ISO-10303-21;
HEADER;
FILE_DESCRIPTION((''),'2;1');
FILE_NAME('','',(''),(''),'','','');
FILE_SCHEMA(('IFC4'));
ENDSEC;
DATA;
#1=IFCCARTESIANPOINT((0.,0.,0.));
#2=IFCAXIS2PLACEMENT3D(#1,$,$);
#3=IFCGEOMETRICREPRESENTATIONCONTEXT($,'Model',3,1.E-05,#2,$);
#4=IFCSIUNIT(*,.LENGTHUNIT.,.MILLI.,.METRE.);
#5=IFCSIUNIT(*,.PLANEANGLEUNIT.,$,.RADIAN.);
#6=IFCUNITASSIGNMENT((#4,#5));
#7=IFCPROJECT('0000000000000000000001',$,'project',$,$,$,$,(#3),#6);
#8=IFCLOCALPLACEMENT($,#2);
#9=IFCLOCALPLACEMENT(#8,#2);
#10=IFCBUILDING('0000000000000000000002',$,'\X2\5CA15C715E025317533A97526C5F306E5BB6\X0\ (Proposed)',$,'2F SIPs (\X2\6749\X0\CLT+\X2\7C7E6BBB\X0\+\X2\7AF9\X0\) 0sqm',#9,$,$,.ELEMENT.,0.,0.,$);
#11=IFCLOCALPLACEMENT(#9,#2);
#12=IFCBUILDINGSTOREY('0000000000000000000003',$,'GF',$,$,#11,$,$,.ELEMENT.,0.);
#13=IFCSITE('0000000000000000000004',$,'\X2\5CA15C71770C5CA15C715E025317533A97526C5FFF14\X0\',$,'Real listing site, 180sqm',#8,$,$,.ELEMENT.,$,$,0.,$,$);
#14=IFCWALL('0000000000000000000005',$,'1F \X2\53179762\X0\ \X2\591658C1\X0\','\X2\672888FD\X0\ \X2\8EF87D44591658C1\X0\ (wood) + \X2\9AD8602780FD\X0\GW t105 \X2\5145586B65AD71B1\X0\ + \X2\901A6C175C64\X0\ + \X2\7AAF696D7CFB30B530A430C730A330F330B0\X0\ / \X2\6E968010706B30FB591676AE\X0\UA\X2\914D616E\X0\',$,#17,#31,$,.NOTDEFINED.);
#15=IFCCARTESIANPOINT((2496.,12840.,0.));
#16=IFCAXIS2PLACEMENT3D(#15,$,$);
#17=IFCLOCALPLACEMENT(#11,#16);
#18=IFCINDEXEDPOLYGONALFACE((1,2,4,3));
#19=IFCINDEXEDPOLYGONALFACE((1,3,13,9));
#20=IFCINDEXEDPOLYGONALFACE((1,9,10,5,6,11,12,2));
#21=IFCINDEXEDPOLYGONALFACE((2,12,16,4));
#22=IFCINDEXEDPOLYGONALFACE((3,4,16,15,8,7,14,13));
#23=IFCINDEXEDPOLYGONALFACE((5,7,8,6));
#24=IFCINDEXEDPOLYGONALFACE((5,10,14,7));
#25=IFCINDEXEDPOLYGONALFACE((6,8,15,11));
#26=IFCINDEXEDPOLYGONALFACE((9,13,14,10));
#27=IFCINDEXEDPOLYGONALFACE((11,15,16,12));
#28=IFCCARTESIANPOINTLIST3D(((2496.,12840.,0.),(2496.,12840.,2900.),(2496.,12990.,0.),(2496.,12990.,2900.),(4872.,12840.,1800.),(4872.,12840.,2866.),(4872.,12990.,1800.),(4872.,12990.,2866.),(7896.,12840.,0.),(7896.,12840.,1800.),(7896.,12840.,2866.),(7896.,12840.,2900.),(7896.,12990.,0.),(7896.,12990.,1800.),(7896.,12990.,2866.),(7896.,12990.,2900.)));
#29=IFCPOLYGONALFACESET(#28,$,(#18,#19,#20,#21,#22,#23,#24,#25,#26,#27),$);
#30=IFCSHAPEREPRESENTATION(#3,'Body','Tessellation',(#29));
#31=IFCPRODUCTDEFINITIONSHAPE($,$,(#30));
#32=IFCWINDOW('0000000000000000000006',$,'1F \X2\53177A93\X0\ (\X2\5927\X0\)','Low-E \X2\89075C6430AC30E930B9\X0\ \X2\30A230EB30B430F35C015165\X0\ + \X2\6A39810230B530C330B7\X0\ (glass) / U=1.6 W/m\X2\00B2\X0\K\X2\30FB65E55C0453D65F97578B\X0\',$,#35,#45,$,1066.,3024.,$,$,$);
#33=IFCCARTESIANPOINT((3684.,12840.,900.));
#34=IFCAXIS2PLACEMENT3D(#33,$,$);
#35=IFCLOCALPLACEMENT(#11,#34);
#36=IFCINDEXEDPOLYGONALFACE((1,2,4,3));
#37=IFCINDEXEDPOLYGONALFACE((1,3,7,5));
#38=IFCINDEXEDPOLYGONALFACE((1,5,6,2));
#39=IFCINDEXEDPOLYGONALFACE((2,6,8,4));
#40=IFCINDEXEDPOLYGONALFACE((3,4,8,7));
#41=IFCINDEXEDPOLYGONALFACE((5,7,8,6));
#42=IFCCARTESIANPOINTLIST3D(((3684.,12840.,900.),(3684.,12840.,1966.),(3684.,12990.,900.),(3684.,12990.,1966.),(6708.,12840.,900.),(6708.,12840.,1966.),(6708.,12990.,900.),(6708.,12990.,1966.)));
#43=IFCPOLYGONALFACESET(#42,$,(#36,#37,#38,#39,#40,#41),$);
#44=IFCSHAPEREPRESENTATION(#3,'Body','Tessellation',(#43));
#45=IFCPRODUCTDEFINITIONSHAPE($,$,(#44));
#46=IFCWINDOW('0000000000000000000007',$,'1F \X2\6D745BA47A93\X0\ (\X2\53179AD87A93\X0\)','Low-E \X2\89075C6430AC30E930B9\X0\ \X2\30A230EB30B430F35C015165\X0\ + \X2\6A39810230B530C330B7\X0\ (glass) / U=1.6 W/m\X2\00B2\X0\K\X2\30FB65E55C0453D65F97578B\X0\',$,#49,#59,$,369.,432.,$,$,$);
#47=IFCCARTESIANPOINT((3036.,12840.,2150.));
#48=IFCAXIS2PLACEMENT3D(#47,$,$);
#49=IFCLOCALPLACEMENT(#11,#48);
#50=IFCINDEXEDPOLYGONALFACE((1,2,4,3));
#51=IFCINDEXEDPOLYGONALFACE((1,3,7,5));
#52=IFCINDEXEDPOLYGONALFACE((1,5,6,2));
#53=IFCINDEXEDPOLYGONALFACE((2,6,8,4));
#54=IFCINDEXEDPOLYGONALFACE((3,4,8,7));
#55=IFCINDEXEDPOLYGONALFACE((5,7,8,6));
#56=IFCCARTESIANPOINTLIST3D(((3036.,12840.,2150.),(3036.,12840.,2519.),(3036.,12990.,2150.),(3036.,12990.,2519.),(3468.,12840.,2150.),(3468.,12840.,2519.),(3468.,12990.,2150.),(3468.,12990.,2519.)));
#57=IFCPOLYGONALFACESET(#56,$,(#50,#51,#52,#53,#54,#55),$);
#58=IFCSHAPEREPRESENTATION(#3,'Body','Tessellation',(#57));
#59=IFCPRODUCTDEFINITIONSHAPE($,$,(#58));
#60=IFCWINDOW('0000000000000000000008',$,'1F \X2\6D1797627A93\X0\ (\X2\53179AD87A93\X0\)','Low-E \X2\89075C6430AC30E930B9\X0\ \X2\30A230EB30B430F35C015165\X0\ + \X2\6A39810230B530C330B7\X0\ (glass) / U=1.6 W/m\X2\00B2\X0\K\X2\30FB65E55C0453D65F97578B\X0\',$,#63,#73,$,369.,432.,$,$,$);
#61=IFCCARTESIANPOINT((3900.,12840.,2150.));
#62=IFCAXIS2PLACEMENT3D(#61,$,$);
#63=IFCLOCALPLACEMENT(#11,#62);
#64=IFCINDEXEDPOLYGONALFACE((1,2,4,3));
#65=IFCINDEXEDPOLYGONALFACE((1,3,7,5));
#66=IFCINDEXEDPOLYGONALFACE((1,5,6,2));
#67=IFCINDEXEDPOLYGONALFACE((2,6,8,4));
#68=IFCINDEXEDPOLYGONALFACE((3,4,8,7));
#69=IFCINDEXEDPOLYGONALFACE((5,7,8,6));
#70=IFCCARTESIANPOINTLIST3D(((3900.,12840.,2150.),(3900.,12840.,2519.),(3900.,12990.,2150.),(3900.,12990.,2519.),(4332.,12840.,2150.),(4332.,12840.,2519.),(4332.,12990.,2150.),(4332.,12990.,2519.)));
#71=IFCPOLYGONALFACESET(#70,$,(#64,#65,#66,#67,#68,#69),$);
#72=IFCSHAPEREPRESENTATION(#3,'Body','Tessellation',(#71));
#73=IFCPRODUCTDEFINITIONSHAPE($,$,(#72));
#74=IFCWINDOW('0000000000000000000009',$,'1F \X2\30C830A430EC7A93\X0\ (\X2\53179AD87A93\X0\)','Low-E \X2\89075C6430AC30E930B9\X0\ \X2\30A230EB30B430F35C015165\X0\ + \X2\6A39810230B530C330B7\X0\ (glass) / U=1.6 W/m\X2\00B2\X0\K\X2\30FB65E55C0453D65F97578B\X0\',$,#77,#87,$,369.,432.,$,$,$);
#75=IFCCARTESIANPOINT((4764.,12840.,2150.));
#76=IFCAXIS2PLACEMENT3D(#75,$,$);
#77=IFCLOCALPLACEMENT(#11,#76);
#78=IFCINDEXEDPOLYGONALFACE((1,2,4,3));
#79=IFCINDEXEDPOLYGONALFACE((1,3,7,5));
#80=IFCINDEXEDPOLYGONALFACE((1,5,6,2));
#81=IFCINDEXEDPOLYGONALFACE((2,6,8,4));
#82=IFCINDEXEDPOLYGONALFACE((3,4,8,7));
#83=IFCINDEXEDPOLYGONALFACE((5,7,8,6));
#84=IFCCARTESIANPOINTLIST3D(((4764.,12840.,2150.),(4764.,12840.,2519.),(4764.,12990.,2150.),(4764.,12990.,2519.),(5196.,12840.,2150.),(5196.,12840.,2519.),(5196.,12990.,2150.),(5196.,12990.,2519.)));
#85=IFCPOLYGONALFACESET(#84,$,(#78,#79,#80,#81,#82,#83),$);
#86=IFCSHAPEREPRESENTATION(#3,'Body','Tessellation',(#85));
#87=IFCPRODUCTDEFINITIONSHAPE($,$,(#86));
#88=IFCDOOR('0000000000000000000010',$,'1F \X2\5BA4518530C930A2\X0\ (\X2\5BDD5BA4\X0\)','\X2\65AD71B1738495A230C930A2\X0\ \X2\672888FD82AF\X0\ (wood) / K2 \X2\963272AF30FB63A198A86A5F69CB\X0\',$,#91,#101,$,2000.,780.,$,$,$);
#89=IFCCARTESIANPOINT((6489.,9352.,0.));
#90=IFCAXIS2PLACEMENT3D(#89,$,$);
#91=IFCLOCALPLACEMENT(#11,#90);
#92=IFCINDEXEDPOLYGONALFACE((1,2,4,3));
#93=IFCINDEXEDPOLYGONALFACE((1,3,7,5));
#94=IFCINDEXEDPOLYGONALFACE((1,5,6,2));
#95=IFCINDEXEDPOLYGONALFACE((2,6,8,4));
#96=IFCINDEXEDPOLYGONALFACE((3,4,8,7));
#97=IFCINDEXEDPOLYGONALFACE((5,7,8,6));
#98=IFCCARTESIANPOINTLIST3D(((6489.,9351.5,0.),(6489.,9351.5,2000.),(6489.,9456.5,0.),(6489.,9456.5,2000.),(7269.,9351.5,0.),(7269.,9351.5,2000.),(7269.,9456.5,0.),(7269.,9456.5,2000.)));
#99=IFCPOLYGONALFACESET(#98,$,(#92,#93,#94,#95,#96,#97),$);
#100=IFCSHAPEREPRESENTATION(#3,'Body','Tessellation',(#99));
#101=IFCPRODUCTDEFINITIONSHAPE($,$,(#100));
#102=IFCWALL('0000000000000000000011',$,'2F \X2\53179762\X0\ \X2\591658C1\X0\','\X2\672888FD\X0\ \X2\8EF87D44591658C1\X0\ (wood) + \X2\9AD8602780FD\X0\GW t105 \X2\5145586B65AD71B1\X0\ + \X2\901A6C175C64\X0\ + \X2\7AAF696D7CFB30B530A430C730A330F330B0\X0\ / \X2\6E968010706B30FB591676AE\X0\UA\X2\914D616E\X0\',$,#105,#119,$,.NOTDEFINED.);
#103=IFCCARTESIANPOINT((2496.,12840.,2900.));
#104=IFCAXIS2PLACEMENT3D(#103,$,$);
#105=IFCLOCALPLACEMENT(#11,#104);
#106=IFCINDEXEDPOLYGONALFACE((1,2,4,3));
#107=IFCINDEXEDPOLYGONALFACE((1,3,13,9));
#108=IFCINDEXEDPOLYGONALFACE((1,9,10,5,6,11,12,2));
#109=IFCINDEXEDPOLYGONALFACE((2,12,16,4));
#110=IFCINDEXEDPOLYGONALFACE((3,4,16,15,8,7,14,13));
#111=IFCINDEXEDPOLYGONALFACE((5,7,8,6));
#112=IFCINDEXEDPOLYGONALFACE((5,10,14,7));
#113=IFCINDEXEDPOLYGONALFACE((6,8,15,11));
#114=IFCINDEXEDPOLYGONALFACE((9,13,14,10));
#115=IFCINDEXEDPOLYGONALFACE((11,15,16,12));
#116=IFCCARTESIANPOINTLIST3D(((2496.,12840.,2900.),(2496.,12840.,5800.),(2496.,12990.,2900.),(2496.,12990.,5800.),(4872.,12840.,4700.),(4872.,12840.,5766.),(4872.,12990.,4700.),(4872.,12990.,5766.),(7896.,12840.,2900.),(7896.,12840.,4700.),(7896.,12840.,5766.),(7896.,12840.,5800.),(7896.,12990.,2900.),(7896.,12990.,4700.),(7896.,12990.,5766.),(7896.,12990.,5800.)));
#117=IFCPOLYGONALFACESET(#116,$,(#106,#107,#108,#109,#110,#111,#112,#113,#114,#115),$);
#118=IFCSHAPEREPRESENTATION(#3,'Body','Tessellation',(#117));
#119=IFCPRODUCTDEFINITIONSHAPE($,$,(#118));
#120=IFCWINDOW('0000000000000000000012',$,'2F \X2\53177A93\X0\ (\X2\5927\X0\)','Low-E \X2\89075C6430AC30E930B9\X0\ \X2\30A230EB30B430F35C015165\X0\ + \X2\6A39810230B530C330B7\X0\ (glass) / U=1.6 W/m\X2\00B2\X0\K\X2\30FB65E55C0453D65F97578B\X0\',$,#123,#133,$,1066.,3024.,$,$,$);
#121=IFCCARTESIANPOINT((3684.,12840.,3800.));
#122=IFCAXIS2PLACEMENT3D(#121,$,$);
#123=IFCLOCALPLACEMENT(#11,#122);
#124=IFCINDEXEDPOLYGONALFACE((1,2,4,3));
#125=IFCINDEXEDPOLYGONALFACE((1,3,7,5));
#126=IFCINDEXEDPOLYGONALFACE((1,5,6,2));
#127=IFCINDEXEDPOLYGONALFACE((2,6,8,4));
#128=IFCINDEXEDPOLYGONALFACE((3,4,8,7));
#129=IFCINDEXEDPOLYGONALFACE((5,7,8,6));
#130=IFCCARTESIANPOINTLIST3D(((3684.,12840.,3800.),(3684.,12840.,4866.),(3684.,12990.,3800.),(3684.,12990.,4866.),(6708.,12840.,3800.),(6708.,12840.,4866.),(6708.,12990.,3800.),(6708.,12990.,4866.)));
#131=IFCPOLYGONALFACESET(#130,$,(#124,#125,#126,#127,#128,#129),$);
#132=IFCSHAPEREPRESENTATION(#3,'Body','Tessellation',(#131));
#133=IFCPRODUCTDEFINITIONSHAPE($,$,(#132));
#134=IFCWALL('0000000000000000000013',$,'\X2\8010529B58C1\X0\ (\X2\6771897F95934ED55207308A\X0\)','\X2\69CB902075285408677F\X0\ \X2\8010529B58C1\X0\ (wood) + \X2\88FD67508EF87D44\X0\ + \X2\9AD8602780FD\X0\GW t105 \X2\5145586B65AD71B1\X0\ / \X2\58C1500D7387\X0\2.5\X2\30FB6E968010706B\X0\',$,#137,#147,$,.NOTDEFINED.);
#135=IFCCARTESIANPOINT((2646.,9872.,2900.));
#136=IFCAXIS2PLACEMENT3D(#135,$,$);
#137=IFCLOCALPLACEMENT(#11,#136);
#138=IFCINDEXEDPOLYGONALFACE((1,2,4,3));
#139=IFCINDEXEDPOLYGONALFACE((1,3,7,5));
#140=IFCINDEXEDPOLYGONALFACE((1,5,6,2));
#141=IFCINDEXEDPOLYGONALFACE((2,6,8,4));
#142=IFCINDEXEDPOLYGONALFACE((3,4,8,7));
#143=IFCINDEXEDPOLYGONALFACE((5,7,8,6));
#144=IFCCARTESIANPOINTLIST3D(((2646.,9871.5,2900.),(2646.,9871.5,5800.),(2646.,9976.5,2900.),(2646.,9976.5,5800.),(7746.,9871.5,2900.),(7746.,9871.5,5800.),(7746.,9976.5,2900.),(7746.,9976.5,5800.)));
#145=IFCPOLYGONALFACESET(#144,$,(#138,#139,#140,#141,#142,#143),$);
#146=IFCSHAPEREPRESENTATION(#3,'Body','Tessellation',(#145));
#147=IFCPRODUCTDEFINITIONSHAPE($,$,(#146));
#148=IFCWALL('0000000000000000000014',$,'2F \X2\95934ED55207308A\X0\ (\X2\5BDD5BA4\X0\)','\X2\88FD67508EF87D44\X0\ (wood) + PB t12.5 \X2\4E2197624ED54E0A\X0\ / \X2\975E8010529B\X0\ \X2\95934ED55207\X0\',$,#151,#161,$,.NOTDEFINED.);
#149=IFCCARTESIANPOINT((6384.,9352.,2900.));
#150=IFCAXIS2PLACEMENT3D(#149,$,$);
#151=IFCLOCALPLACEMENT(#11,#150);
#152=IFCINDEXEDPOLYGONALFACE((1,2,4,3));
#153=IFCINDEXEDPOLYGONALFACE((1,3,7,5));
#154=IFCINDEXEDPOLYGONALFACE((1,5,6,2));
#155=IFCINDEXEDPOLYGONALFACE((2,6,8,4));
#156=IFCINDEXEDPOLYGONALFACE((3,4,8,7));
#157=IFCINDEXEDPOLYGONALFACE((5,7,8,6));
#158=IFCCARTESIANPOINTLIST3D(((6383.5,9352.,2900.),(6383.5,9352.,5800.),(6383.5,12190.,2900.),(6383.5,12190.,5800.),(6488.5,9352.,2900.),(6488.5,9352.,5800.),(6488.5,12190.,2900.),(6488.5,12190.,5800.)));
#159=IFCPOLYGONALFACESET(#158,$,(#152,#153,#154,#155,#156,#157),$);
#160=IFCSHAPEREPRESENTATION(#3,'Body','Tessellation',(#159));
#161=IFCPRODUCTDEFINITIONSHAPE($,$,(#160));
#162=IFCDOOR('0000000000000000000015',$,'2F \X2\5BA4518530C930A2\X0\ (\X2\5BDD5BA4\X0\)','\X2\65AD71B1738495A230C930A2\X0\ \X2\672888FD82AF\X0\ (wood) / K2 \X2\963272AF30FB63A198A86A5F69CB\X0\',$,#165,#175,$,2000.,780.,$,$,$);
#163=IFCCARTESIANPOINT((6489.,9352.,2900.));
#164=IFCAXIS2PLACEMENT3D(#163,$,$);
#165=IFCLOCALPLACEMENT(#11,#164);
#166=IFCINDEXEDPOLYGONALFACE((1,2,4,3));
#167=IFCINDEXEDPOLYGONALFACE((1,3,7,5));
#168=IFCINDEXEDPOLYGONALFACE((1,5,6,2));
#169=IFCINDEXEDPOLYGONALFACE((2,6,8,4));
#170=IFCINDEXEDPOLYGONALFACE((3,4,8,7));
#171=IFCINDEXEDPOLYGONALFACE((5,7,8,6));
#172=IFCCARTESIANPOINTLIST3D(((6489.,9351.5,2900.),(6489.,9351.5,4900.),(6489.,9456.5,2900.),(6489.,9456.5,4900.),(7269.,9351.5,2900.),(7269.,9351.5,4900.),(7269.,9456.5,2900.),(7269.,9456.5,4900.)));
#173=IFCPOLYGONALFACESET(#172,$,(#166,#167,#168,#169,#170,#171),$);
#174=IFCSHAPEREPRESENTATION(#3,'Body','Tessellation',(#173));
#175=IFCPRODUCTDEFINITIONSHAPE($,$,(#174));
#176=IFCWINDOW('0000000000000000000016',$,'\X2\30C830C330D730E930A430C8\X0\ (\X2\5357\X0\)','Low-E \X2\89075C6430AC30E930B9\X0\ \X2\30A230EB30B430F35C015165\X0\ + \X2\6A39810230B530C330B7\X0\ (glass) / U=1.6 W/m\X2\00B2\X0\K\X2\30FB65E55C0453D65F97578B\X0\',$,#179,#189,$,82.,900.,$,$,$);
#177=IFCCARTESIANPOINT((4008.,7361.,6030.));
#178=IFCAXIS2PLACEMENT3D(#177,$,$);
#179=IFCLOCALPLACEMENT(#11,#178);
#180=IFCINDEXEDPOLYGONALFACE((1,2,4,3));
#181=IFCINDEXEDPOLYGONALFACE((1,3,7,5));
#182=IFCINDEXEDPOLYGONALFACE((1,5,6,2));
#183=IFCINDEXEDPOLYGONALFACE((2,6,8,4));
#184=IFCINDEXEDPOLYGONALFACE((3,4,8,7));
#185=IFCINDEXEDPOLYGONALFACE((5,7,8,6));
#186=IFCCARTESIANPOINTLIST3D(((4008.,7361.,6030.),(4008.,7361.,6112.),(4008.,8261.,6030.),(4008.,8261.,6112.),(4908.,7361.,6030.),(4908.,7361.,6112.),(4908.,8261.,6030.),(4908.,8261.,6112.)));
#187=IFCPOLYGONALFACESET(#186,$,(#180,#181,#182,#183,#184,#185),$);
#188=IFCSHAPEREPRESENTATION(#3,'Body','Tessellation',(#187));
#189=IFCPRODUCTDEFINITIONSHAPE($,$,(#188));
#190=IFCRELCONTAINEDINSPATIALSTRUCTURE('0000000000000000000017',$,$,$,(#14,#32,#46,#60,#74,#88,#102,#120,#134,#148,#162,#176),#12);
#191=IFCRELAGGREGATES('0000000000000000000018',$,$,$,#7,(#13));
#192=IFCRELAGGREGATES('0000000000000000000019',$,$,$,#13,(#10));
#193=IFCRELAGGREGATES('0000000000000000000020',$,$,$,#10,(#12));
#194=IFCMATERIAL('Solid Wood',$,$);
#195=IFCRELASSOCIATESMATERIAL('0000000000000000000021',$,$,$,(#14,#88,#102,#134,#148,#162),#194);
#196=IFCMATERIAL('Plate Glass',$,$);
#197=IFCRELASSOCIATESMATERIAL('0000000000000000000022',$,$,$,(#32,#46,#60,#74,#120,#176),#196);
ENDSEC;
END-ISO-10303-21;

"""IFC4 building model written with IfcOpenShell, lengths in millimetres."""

from ifc_helpers import new_model, si_unit, frame, frame_2d, origin, place, context, project, spatial, rectangle, extrude, material, element, fill, save


model = new_model("IFC4")

# Units and contexts
model_context = context("Model", 3, precision=1e-05, world=origin())
ifc_project = project(units=[si_unit("LENGTHUNIT", "METRE", prefix="MILLI"), si_unit("PLANEANGLEUNIT", "RADIAN")], contexts=[model_context])

# Site, building, storey
site_placement = place(None, origin())
site = spatial("IfcSite", under=ifc_project, at=site_placement, Name="岡山県岡山市北区青江４", ObjectType="Real listing site, 180sqm", CompositionType="ELEMENT", RefElevation=0.0)
building_placement = place(site_placement, origin())
building = spatial("IfcBuilding", under=site, at=building_placement, Name="岡山市北区青江の家 (Proposed)", ObjectType="2F SIPs (杉CLT+籾殻+竹) 0sqm", CompositionType="ELEMENT", ElevationOfRefHeight=0.0, ElevationOfTerrain=0.0)
storey_placement = place(building_placement, origin())
storey = spatial("IfcBuildingStorey", under=building, at=storey_placement, Name="GF", CompositionType="ELEMENT", Elevation=0.0)

# Wall, openings, windows
ifc_material_1 = material(Name="Solid Wood")
wall_1_placement = place(storey_placement, frame((2496.0, 12840.0, 0.0)))
wall_1 = element("IfcWall", 1, at=wall_1_placement, inside=storey, material=ifc_material_1, Name="1F 北面 外壁", Description="木製 軸組外壁 (wood) + 高性能GW t105 充填断熱 + 通気層 + 窯業系サイディング / 準耐火・外皮UA配慮", PredefinedType="NOTDEFINED", context=model_context, shape_type="SweptSolid", body=[
    extrude(rectangle(XDim=5400.0, YDim=150.0, at=frame_2d((2700.0, 75.0))), frame((2496.0, 12840.0, 0.0)), (0.0, 0.0, 1.0), 2900.0),
])
opening_1_placement = place(storey_placement, frame((3684.0, 12840.0, 900.0)))
opening_1 = element("IfcOpeningElement", 2, at=opening_1_placement, cuts=wall_1, PredefinedType="NOTDEFINED", context=model_context, shape_type="SweptSolid", body=[
    extrude(rectangle(XDim=3024.0, YDim=150.0, at=frame_2d((1512.0, 75.0))), frame((3684.0, 12840.0, 900.0)), (0.0, 0.0, 1.0), 1066.0),
])
opening_2_placement = place(storey_placement, frame((3036.0, 12840.0, 2150.0)))
opening_2 = element("IfcOpeningElement", 3, at=opening_2_placement, cuts=wall_1, PredefinedType="NOTDEFINED", context=model_context, shape_type="SweptSolid", body=[
    extrude(rectangle(XDim=432.0, YDim=150.0, at=frame_2d((216.0, 75.0))), frame((3036.0, 12840.0, 2150.0)), (0.0, 0.0, 1.0), 369.0),
])
opening_3_placement = place(storey_placement, frame((3900.0, 12840.0, 2150.0)))
opening_3 = element("IfcOpeningElement", 4, at=opening_3_placement, cuts=wall_1, PredefinedType="NOTDEFINED", context=model_context, shape_type="SweptSolid", body=[
    extrude(rectangle(XDim=432.0, YDim=150.0, at=frame_2d((216.0, 75.0))), frame((3900.0, 12840.0, 2150.0)), (0.0, 0.0, 1.0), 369.0),
])
opening_4_placement = place(storey_placement, frame((4764.0, 12840.0, 2150.0)))
opening_4 = element("IfcOpeningElement", 5, at=opening_4_placement, cuts=wall_1, PredefinedType="NOTDEFINED", context=model_context, shape_type="SweptSolid", body=[
    extrude(rectangle(XDim=432.0, YDim=150.0, at=frame_2d((216.0, 75.0))), frame((4764.0, 12840.0, 2150.0)), (0.0, 0.0, 1.0), 369.0),
])
ifc_material_2 = material(Name="Plate Glass")
window_1_placement = place(storey_placement, frame((3684.0, 12840.0, 900.0)))
window_1 = element("IfcWindow", 6, at=window_1_placement, inside=storey, material=ifc_material_2, Name="1F 北窓 (大)", Description="Low-E 複層ガラス アルゴン封入 + 樹脂サッシ (glass) / U=1.6 W/m²K・日射取得型", OverallHeight=1066.0, OverallWidth=3024.0, context=model_context, shape_type="SweptSolid", body=[
    extrude(rectangle(XDim=3024.0, YDim=150.0, at=frame_2d((1512.0, 75.0))), frame((3684.0, 12840.0, 900.0)), (0.0, 0.0, 1.0), 1066.0),
])
fill(opening_1, window_1)
window_2_placement = place(storey_placement, frame((3036.0, 12840.0, 2150.0)))
window_2 = element("IfcWindow", 7, at=window_2_placement, inside=storey, material=ifc_material_2, Name="1F 浴室窓 (北高窓)", Description="Low-E 複層ガラス アルゴン封入 + 樹脂サッシ (glass) / U=1.6 W/m²K・日射取得型", OverallHeight=369.0, OverallWidth=432.0, context=model_context, shape_type="SweptSolid", body=[
    extrude(rectangle(XDim=432.0, YDim=150.0, at=frame_2d((216.0, 75.0))), frame((3036.0, 12840.0, 2150.0)), (0.0, 0.0, 1.0), 369.0),
])
fill(opening_2, window_2)
window_3_placement = place(storey_placement, frame((3900.0, 12840.0, 2150.0)))
window_3 = element("IfcWindow", 8, at=window_3_placement, inside=storey, material=ifc_material_2, Name="1F 洗面窓 (北高窓)", Description="Low-E 複層ガラス アルゴン封入 + 樹脂サッシ (glass) / U=1.6 W/m²K・日射取得型", OverallHeight=369.0, OverallWidth=432.0, context=model_context, shape_type="SweptSolid", body=[
    extrude(rectangle(XDim=432.0, YDim=150.0, at=frame_2d((216.0, 75.0))), frame((3900.0, 12840.0, 2150.0)), (0.0, 0.0, 1.0), 369.0),
])
fill(opening_3, window_3)
window_4_placement = place(storey_placement, frame((4764.0, 12840.0, 2150.0)))
window_4 = element("IfcWindow", 9, at=window_4_placement, inside=storey, material=ifc_material_2, Name="1F トイレ窓 (北高窓)", Description="Low-E 複層ガラス アルゴン封入 + 樹脂サッシ (glass) / U=1.6 W/m²K・日射取得型", OverallHeight=369.0, OverallWidth=432.0, context=model_context, shape_type="SweptSolid", body=[
    extrude(rectangle(XDim=432.0, YDim=150.0, at=frame_2d((216.0, 75.0))), frame((4764.0, 12840.0, 2150.0)), (0.0, 0.0, 1.0), 369.0),
])
fill(opening_4, window_4)

# Door
door_1_placement = place(storey_placement, frame((6489.0, 9352.0, 0.0)))
element("IfcDoor", 10, at=door_1_placement, inside=storey, material=ifc_material_1, Name="1F 室内ドア (寝室)", Description="断熱玄関ドア 木製芯 (wood) / K2 防犯・採風機構", OverallHeight=2000.0, OverallWidth=780.0, context=model_context, shape_type="SweptSolid", body=[
    extrude(rectangle(XDim=780.0, YDim=105.0, at=frame_2d((390.0, 52.0))), frame((6489.0, 9352.0, 0.0)), (0.0, 0.0, 1.0), 2000.0),
])

# Wall, opening, window
wall_2_placement = place(storey_placement, frame((2496.0, 12840.0, 2900.0)))
wall_2 = element("IfcWall", 11, at=wall_2_placement, inside=storey, material=ifc_material_1, Name="2F 北面 外壁", Description="木製 軸組外壁 (wood) + 高性能GW t105 充填断熱 + 通気層 + 窯業系サイディング / 準耐火・外皮UA配慮", PredefinedType="NOTDEFINED", context=model_context, shape_type="SweptSolid", body=[
    extrude(rectangle(XDim=5400.0, YDim=150.0, at=frame_2d((2700.0, 75.0))), frame((2496.0, 12840.0, 2900.0)), (0.0, 0.0, 1.0), 2900.0),
])
opening_5_placement = place(storey_placement, frame((3684.0, 12840.0, 3800.0)))
opening_5 = element("IfcOpeningElement", 12, at=opening_5_placement, cuts=wall_2, PredefinedType="NOTDEFINED", context=model_context, shape_type="SweptSolid", body=[
    extrude(rectangle(XDim=3024.0, YDim=150.0, at=frame_2d((1512.0, 75.0))), frame((3684.0, 12840.0, 3800.0)), (0.0, 0.0, 1.0), 1066.0),
])
window_5_placement = place(storey_placement, frame((3684.0, 12840.0, 3800.0)))
window_5 = element("IfcWindow", 13, at=window_5_placement, inside=storey, material=ifc_material_2, Name="2F 北窓 (大)", Description="Low-E 複層ガラス アルゴン封入 + 樹脂サッシ (glass) / U=1.6 W/m²K・日射取得型", OverallHeight=1066.0, OverallWidth=3024.0, context=model_context, shape_type="SweptSolid", body=[
    extrude(rectangle(XDim=3024.0, YDim=150.0, at=frame_2d((1512.0, 75.0))), frame((3684.0, 12840.0, 3800.0)), (0.0, 0.0, 1.0), 1066.0),
])
fill(opening_5, window_5)

# Walls
wall_3_placement = place(storey_placement, frame((2646.0, 9872.0, 2900.0)))
element("IfcWall", 14, at=wall_3_placement, inside=storey, material=ifc_material_1, Name="耐力壁 (東西間仕切り)", Description="構造用合板 耐力壁 (wood) + 製材軸組 + 高性能GW t105 充填断熱 / 壁倍率2.5・準耐火", PredefinedType="NOTDEFINED", context=model_context, shape_type="SweptSolid", body=[
    extrude(rectangle(XDim=5100.0, YDim=105.0, at=frame_2d((2550.0, 52.0))), frame((2646.0, 9872.0, 2900.0)), (0.0, 0.0, 1.0), 2900.0),
])
wall_4_placement = place(storey_placement, frame((6384.0, 9352.0, 2900.0)))
element("IfcWall", 15, at=wall_4_placement, inside=storey, material=ifc_material_1, Name="2F 間仕切り (寝室)", Description="製材軸組 (wood) + PB t12.5 両面仕上 / 非耐力 間仕切", PredefinedType="NOTDEFINED", context=model_context, shape_type="SweptSolid", body=[
    extrude(rectangle(XDim=105.0, YDim=2838.0, at=frame_2d((52.0, 1419.0))), frame((6384.0, 9352.0, 2900.0)), (0.0, 0.0, 1.0), 2900.0),
])

# Door
door_2_placement = place(storey_placement, frame((6489.0, 9352.0, 2900.0)))
element("IfcDoor", 16, at=door_2_placement, inside=storey, material=ifc_material_1, Name="2F 室内ドア (寝室)", Description="断熱玄関ドア 木製芯 (wood) / K2 防犯・採風機構", OverallHeight=2000.0, OverallWidth=780.0, context=model_context, shape_type="SweptSolid", body=[
    extrude(rectangle(XDim=780.0, YDim=105.0, at=frame_2d((390.0, 52.0))), frame((6489.0, 9352.0, 2900.0)), (0.0, 0.0, 1.0), 2000.0),
])

# Window
window_6_placement = place(storey_placement, frame((4008.0, 7361.0, 6030.0)))
element("IfcWindow", 17, at=window_6_placement, inside=storey, material=ifc_material_2, Name="トップライト (南)", Description="Low-E 複層ガラス アルゴン封入 + 樹脂サッシ (glass) / U=1.6 W/m²K・日射取得型", OverallHeight=82.0, OverallWidth=900.0, context=model_context, shape_type="SweptSolid", body=[
    extrude(rectangle(XDim=900.0, YDim=900.0, at=frame_2d((450.0, 450.0))), frame((4008.0, 7361.0, 6030.0)), (0.0, 0.0, 1.0), 82.0),
])

save(model, "model.ifc")
